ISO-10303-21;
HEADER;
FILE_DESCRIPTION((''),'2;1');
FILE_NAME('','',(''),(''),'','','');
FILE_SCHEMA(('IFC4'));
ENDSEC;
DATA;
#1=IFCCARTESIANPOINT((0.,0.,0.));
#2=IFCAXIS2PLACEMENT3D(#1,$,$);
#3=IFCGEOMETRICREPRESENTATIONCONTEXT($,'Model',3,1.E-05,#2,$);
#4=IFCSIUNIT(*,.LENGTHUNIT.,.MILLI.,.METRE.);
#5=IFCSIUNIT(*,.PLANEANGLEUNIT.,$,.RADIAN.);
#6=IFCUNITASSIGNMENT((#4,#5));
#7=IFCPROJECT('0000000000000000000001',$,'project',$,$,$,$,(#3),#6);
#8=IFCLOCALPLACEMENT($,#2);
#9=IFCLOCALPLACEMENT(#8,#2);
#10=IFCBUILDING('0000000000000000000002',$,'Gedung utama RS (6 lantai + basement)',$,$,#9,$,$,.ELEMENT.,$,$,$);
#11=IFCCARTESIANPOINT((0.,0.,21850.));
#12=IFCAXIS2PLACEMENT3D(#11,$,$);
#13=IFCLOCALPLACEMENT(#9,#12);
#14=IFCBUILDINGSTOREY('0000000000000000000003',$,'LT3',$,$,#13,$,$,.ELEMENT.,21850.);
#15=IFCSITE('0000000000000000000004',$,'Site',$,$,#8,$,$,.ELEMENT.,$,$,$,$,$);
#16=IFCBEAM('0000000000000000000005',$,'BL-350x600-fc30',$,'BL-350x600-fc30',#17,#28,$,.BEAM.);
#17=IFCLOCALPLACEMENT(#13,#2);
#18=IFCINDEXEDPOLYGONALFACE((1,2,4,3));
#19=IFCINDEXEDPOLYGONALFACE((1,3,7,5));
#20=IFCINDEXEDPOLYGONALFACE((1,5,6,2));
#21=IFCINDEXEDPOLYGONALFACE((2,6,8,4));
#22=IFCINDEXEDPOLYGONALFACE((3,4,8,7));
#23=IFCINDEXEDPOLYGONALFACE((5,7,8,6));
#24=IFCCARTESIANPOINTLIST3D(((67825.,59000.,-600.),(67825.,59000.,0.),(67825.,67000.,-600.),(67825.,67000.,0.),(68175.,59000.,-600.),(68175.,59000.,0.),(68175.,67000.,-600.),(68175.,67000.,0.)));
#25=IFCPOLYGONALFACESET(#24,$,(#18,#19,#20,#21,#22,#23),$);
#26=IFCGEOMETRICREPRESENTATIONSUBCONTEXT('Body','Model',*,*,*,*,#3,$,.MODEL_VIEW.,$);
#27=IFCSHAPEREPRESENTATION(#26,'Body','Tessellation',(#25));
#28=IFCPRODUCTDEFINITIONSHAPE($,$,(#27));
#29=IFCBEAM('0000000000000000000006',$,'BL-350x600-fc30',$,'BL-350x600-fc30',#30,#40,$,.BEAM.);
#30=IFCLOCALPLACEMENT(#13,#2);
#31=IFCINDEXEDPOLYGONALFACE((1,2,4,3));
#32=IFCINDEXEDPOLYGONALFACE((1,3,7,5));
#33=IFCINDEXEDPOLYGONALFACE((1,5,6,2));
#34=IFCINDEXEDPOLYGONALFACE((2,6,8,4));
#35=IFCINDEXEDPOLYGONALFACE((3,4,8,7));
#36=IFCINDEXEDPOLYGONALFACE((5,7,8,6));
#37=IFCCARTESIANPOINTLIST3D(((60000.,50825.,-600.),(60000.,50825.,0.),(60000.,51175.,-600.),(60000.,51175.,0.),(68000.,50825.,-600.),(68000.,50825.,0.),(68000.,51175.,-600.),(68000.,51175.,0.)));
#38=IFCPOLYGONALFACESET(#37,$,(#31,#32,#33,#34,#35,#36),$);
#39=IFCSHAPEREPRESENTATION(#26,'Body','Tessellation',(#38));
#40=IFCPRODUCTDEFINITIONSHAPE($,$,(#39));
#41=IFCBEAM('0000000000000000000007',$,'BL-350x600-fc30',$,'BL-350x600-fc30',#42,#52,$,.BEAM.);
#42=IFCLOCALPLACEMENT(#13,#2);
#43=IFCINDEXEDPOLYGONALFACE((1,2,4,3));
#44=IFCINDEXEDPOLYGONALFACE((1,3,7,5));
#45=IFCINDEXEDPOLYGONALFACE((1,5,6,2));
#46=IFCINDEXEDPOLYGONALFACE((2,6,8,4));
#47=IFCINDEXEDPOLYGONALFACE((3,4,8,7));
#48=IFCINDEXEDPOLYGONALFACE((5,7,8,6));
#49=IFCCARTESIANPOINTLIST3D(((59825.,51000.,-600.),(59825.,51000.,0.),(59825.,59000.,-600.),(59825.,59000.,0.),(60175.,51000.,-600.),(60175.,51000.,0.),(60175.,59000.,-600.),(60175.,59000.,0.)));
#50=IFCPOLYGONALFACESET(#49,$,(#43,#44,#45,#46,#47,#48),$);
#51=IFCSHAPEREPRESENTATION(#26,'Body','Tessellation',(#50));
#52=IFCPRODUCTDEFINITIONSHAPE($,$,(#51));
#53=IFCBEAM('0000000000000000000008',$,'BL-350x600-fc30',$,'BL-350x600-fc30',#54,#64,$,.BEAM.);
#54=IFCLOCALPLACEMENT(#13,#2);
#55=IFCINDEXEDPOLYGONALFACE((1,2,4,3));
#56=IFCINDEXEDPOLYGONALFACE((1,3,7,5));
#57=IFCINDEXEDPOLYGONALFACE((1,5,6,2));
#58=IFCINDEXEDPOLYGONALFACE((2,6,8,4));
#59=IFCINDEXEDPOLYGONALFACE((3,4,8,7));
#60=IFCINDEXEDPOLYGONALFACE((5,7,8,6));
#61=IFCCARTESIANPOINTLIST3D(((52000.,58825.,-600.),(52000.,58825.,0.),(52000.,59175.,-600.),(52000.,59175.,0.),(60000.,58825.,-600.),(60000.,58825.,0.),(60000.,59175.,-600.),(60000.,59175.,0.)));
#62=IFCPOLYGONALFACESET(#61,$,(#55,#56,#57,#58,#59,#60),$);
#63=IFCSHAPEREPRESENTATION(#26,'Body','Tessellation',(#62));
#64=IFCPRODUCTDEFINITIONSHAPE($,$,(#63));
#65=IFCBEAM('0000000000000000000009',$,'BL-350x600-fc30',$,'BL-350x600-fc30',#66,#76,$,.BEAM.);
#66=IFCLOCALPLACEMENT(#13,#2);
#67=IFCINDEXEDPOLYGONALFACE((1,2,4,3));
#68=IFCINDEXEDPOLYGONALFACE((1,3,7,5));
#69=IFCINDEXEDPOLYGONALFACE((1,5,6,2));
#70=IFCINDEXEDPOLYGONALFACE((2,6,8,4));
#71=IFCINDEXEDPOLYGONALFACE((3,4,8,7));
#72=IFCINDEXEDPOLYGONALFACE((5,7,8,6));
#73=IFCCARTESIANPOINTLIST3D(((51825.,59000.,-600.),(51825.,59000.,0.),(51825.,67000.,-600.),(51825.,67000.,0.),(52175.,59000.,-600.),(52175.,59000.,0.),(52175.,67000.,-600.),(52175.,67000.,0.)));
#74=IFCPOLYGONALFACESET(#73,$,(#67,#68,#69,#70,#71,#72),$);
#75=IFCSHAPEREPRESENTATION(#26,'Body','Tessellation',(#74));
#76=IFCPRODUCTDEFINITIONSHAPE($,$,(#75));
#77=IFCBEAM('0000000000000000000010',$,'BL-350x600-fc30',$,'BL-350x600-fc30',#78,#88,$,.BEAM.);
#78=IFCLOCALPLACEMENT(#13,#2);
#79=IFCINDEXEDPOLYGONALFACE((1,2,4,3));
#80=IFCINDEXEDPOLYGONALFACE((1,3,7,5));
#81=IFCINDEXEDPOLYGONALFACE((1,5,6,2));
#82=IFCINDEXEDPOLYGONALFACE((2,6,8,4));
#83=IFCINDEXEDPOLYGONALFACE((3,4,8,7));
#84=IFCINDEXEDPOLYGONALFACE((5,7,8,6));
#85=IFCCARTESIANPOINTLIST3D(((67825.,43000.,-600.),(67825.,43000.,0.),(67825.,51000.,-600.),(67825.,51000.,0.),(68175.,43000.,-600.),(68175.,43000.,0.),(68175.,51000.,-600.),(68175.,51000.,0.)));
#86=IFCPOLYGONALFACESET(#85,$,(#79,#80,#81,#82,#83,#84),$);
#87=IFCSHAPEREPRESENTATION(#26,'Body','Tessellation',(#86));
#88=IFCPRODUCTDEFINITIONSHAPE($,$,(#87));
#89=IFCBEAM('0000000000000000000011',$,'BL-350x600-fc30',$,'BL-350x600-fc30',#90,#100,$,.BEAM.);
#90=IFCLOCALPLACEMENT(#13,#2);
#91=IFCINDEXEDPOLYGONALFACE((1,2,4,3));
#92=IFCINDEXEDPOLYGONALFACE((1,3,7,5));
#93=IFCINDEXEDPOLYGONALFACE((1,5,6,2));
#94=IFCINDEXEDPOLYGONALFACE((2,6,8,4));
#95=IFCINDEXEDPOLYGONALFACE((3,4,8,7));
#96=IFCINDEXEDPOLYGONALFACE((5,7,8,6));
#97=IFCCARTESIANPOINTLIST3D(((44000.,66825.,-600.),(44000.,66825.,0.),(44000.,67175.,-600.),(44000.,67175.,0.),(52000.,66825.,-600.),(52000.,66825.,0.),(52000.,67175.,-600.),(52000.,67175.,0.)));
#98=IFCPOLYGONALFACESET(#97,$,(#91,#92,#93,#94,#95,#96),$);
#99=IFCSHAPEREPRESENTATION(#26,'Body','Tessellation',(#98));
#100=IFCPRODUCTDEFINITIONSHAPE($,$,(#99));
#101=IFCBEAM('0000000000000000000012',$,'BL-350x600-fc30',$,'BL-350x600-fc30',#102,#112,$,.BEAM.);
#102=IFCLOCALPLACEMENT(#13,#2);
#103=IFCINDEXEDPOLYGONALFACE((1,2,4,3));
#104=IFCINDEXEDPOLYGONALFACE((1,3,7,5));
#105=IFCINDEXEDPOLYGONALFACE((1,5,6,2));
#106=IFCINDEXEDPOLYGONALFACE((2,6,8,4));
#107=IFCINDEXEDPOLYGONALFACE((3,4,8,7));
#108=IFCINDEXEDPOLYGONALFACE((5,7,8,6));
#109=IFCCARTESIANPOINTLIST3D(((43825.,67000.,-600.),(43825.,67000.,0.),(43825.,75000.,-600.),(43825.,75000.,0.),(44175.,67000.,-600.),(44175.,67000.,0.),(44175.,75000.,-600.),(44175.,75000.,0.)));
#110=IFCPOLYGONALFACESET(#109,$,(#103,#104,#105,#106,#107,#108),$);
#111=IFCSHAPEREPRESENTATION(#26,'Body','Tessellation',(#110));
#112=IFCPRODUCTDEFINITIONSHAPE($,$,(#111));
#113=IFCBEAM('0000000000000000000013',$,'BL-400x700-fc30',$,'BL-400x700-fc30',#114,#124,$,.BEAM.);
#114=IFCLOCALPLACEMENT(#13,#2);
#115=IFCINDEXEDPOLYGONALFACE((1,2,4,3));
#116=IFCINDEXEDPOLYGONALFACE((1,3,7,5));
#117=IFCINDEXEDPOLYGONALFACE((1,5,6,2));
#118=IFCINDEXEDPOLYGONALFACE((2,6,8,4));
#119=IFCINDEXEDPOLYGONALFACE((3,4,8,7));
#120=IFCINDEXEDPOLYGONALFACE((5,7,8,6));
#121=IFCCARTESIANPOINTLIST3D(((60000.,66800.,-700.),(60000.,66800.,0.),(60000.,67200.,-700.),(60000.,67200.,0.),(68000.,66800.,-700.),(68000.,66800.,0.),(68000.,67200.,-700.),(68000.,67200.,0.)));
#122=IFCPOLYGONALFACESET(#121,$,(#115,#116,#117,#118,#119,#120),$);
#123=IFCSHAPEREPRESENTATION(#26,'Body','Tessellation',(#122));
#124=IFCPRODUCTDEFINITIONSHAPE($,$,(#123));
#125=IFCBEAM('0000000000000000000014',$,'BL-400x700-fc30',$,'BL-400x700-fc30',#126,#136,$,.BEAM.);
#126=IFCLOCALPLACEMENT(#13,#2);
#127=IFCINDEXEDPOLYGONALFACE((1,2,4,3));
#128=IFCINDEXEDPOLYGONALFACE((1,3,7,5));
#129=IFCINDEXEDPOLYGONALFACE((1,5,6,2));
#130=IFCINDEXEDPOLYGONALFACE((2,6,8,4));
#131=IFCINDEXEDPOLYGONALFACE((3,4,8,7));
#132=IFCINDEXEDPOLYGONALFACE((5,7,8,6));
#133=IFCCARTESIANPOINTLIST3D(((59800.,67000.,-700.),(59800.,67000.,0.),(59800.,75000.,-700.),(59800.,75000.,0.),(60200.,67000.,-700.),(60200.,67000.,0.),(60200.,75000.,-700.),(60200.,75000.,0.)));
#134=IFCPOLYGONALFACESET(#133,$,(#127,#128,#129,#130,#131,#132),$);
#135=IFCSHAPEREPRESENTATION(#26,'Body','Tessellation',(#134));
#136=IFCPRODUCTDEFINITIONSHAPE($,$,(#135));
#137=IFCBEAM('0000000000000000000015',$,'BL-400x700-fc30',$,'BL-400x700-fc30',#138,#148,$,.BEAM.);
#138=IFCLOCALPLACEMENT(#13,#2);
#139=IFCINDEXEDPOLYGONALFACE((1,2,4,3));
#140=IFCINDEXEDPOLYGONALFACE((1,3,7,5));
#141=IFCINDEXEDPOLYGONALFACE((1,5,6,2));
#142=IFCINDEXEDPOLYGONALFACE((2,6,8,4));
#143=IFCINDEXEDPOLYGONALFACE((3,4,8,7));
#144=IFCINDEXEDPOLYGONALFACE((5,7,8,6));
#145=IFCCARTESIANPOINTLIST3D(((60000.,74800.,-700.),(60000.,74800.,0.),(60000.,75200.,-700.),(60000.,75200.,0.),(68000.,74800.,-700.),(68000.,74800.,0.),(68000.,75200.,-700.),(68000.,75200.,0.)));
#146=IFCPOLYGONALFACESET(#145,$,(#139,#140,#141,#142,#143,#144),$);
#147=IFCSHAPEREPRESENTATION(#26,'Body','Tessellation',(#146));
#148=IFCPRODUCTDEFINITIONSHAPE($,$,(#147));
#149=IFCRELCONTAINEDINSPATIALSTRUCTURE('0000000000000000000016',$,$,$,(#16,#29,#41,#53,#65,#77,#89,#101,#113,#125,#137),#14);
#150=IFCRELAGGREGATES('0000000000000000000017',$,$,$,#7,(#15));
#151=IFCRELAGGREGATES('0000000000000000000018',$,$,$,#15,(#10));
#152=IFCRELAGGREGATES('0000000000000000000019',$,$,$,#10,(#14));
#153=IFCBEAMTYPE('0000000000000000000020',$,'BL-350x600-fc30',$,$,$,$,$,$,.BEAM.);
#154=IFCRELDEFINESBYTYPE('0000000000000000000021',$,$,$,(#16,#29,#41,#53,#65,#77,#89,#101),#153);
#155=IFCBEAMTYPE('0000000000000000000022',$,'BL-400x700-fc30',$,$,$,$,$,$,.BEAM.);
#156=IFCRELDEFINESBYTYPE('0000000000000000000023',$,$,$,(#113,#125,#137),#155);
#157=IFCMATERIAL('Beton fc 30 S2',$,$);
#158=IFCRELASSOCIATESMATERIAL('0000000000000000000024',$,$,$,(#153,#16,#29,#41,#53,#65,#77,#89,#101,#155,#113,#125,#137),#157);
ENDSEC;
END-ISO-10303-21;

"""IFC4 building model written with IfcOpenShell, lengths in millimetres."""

from ifc_helpers import new_model, si_unit, frame, origin, origin_2d, place, context, subcontext, project, spatial, rectangle, extrude, material, material_profile, profile_set, profile_usage, type_object, element, save


model = new_model("IFC4")

# Units and contexts
model_context = context("Model", 3, precision=1e-05, world=origin())
body_context = subcontext(model_context, "Body", "Model", "MODEL_VIEW")
ifc_project = project(units=[si_unit("LENGTHUNIT", "METRE", prefix="MILLI"), si_unit("PLANEANGLEUNIT", "RADIAN")], contexts=[model_context])

# Site, building, storey
site_placement = place(None, origin())
site = spatial("IfcSite", under=ifc_project, at=site_placement, Name="Site", CompositionType="ELEMENT")
building_placement = place(site_placement, origin())
building = spatial("IfcBuilding", under=site, at=building_placement, Name="Gedung utama RS (6 lantai + basement)", CompositionType="ELEMENT")
storey_placement = place(building_placement, frame((0.0, 0.0, 21850.0)))
storey = spatial("IfcBuildingStorey", under=building, at=storey_placement, Name="LT3", CompositionType="ELEMENT", Elevation=21850.0)

# Beams
ifc_material = material(Name="Beton fc 30 S2")
ifc_material_profile_1 = material_profile(ifc_material, rectangle(XDim=350.0, YDim=600.0, at=origin_2d()), Name="BL-350x600-fc30")
ifc_profile_set_1 = profile_set([ifc_material_profile_1], Name="BL-350x600-fc30")
ifc_profile_usage_1 = profile_usage(ifc_profile_set_1, cardinal=8)
beam_type_1 = type_object("IfcBeamType", Name="BL-350x600-fc30", PredefinedType="BEAM", material=ifc_profile_set_1)
beam_1_placement = place(storey_placement, frame((68000.0, 59000.0, -300.0)))
element("IfcBeam", 1, at=beam_1_placement, inside=storey, type_object=beam_type_1, material=ifc_profile_usage_1, Name="BL-350x600-fc30", ObjectType="BL-350x600-fc30", PredefinedType="BEAM", context=body_context, shape_type="SweptSolid", body=[
    extrude(rectangle(XDim=350.0, YDim=600.0, at=origin_2d()), frame((0.0, 0.0, 0.0), z_axis=(0.0, 1.0, 0.0), x_axis=(-1.0, 0.0, 0.0)), (0.0, 0.0, 1.0), 8000.0),
])
beam_2_placement = place(storey_placement, frame((60000.0, 51000.0, -300.0)))
element("IfcBeam", 2, at=beam_2_placement, inside=storey, type_object=beam_type_1, material=ifc_profile_usage_1, Name="BL-350x600-fc30", ObjectType="BL-350x600-fc30", PredefinedType="BEAM", context=body_context, shape_type="SweptSolid", body=[
    extrude(rectangle(XDim=350.0, YDim=600.0, at=origin_2d()), frame((0.0, 0.0, 0.0), z_axis=(1.0, 0.0, 0.0), x_axis=(0.0, 1.0, 0.0)), (0.0, 0.0, 1.0), 8000.0),
])
beam_3_placement = place(storey_placement, frame((60000.0, 51000.0, -300.0)))
element("IfcBeam", 3, at=beam_3_placement, inside=storey, type_object=beam_type_1, material=ifc_profile_usage_1, Name="BL-350x600-fc30", ObjectType="BL-350x600-fc30", PredefinedType="BEAM", context=body_context, shape_type="SweptSolid", body=[
    extrude(rectangle(XDim=350.0, YDim=600.0, at=origin_2d()), frame((0.0, 0.0, 0.0), z_axis=(0.0, 1.0, 0.0), x_axis=(-1.0, 0.0, 0.0)), (0.0, 0.0, 1.0), 8000.0),
])
beam_4_placement = place(storey_placement, frame((52000.0, 59000.0, -300.0)))
element("IfcBeam", 4, at=beam_4_placement, inside=storey, type_object=beam_type_1, material=ifc_profile_usage_1, Name="BL-350x600-fc30", ObjectType="BL-350x600-fc30", PredefinedType="BEAM", context=body_context, shape_type="SweptSolid", body=[
    extrude(rectangle(XDim=350.0, YDim=600.0, at=origin_2d()), frame((0.0, 0.0, 0.0), z_axis=(1.0, 0.0, 0.0), x_axis=(0.0, 1.0, 0.0)), (0.0, 0.0, 1.0), 8000.0),
])
for number, where, name in (
    (5, (52000.0, 59000.0, -300.0), "BL-350x600-fc30"),
    (6, (68000.0, 43000.0, -300.0), "BL-350x600-fc30"),
):
    element("IfcBeam", number, at=place(storey_placement, frame(where)), inside=storey, type_object=beam_type_1, material=ifc_profile_usage_1, Name=name, ObjectType="BL-350x600-fc30", PredefinedType="BEAM", context=body_context, shape_type="SweptSolid", body=[
        extrude(rectangle(XDim=350.0, YDim=600.0, at=origin_2d()), frame((0.0, 0.0, 0.0), z_axis=(0.0, 1.0, 0.0), x_axis=(-1.0, 0.0, 0.0)), (0.0, 0.0, 1.0), 8000.0),
    ])
beam_5_placement = place(storey_placement, frame((44000.0, 67000.0, -300.0)))
element("IfcBeam", 7, at=beam_5_placement, inside=storey, type_object=beam_type_1, material=ifc_profile_usage_1, Name="BL-350x600-fc30", ObjectType="BL-350x600-fc30", PredefinedType="BEAM", context=body_context, shape_type="SweptSolid", body=[
    extrude(rectangle(XDim=350.0, YDim=600.0, at=origin_2d()), frame((0.0, 0.0, 0.0), z_axis=(1.0, 0.0, 0.0), x_axis=(0.0, 1.0, 0.0)), (0.0, 0.0, 1.0), 8000.0),
])
beam_6_placement = place(storey_placement, frame((44000.0, 67000.0, -300.0)))
element("IfcBeam", 8, at=beam_6_placement, inside=storey, type_object=beam_type_1, material=ifc_profile_usage_1, Name="BL-350x600-fc30", ObjectType="BL-350x600-fc30", PredefinedType="BEAM", context=body_context, shape_type="SweptSolid", body=[
    extrude(rectangle(XDim=350.0, YDim=600.0, at=origin_2d()), frame((0.0, 0.0, 0.0), z_axis=(0.0, 1.0, 0.0), x_axis=(-1.0, 0.0, 0.0)), (0.0, 0.0, 1.0), 8000.0),
])
ifc_material_profile_2 = material_profile(ifc_material, rectangle(XDim=400.0, YDim=700.0, at=origin_2d()), Name="BL-400x700-fc30")
ifc_profile_set_2 = profile_set([ifc_material_profile_2], Name="BL-400x700-fc30")
ifc_profile_usage_2 = profile_usage(ifc_profile_set_2, cardinal=8)
beam_type_2 = type_object("IfcBeamType", Name="BL-400x700-fc30", PredefinedType="BEAM", material=ifc_profile_set_2)
beam_7_placement = place(storey_placement, frame((60000.0, 67000.0, -350.0)))
element("IfcBeam", 9, at=beam_7_placement, inside=storey, type_object=beam_type_2, material=ifc_profile_usage_2, Name="BL-400x700-fc30", ObjectType="BL-400x700-fc30", PredefinedType="BEAM", context=body_context, shape_type="SweptSolid", body=[
    extrude(rectangle(XDim=400.0, YDim=700.0, at=origin_2d()), frame((0.0, 0.0, 0.0), z_axis=(1.0, 0.0, 0.0), x_axis=(0.0, 1.0, 0.0)), (0.0, 0.0, 1.0), 8000.0),
])
beam_8_placement = place(storey_placement, frame((60000.0, 67000.0, -350.0)))
element("IfcBeam", 10, at=beam_8_placement, inside=storey, type_object=beam_type_2, material=ifc_profile_usage_2, Name="BL-400x700-fc30", ObjectType="BL-400x700-fc30", PredefinedType="BEAM", context=body_context, shape_type="SweptSolid", body=[
    extrude(rectangle(XDim=400.0, YDim=700.0, at=origin_2d()), frame((0.0, 0.0, 0.0), z_axis=(0.0, 1.0, 0.0), x_axis=(-1.0, 0.0, 0.0)), (0.0, 0.0, 1.0), 8000.0),
])
beam_9_placement = place(storey_placement, frame((60000.0, 75000.0, -350.0)))
element("IfcBeam", 11, at=beam_9_placement, inside=storey, type_object=beam_type_2, material=ifc_profile_usage_2, Name="BL-400x700-fc30", ObjectType="BL-400x700-fc30", PredefinedType="BEAM", context=body_context, shape_type="SweptSolid", body=[
    extrude(rectangle(XDim=400.0, YDim=700.0, at=origin_2d()), frame((0.0, 0.0, 0.0), z_axis=(1.0, 0.0, 0.0), x_axis=(0.0, 1.0, 0.0)), (0.0, 0.0, 1.0), 8000.0),
])

save(model, "model.ifc")
